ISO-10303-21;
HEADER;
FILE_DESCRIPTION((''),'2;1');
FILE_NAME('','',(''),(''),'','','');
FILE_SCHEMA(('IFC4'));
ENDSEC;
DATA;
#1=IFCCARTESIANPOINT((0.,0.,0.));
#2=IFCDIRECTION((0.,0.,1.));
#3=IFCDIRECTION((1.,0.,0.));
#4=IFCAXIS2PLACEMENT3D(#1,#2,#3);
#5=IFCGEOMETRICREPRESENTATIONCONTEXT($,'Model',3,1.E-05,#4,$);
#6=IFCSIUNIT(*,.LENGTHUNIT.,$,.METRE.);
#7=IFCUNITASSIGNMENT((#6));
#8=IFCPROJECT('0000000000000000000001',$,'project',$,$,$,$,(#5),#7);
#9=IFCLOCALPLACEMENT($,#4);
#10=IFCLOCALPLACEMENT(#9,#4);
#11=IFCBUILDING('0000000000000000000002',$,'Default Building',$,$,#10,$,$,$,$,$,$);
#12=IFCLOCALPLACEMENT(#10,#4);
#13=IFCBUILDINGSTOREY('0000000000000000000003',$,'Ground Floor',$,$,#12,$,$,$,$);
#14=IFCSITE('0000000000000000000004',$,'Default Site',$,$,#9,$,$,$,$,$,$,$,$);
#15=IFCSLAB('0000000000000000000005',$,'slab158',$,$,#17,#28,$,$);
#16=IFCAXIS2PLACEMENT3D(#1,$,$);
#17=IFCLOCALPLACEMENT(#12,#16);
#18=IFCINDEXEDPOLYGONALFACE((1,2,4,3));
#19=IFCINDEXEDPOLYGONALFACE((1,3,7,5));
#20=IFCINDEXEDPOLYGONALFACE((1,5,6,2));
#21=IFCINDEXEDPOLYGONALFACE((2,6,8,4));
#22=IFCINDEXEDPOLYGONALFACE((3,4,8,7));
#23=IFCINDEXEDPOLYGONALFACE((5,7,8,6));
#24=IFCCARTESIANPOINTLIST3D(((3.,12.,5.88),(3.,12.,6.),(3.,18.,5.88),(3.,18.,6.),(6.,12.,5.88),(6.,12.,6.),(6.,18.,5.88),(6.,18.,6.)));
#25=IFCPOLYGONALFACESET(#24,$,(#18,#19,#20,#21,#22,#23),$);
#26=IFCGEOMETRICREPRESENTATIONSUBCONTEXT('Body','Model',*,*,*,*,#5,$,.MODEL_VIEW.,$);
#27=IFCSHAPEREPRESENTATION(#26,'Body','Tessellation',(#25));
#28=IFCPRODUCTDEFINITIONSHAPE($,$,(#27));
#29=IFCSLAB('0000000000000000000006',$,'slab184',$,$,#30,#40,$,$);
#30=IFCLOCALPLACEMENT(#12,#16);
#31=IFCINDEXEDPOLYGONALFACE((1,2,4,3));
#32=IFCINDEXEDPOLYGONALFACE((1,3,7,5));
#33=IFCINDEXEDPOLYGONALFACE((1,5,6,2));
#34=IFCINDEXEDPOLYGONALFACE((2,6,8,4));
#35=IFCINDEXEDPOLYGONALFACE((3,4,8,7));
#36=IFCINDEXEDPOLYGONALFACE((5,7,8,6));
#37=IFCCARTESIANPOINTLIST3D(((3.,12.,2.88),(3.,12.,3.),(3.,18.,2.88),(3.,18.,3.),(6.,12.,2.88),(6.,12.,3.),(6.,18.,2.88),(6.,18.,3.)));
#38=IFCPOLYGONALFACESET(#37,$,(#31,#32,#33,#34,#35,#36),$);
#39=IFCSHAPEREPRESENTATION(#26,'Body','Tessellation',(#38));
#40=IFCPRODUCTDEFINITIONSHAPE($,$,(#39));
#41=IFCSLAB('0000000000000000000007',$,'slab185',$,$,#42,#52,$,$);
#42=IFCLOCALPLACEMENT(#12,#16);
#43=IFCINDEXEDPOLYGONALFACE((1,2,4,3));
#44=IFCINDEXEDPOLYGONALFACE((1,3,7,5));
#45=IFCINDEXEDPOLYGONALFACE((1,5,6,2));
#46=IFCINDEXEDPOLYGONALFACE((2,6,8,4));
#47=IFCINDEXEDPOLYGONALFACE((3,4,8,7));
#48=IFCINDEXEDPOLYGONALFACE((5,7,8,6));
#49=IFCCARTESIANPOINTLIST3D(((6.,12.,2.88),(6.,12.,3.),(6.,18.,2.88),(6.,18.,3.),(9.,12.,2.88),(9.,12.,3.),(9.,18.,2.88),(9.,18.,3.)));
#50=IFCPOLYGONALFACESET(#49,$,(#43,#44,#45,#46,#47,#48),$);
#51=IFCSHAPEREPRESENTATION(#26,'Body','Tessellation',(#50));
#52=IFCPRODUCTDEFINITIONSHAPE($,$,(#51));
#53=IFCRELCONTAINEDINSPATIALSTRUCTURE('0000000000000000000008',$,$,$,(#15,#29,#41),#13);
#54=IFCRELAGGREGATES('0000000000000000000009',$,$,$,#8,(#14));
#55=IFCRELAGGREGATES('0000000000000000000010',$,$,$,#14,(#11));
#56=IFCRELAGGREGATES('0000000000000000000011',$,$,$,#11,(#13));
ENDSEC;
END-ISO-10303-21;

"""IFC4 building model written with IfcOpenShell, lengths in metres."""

from ifc_helpers import new_model, si_unit, frame, origin_with_axes, place, context, subcontext, project, spatial, indexed_curve, outline, extrude, element, save


model = new_model("IFC4")

# Units and contexts
model_context = context("Model", 3, precision=1e-05, world=origin_with_axes())
body_context = subcontext(model_context, "Body", "Model", "MODEL_VIEW")
ifc_project = project(units=[si_unit("LENGTHUNIT", "METRE")], contexts=[model_context])

# Site, building, storey
site_placement = place(None, origin_with_axes())
site = spatial("IfcSite", under=ifc_project, at=site_placement, Name="Default Site")
building_placement = place(site_placement, origin_with_axes())
building = spatial("IfcBuilding", under=site, at=building_placement, Name="Default Building")
storey_placement = place(building_placement, origin_with_axes())
storey = spatial("IfcBuildingStorey", under=building, at=storey_placement, Name="Ground Floor")

# Slabs
for number, where, z_axis, x_axis, name in (
    (1, (3.0, 12.0, 5.88), (0.0, 0.0, 1.0), (1.0, 0.0, 0.0), "slab158"),
    (2, (3.0, 12.0, 2.88), (0.0, 0.0, 1.0), (1.0, 0.0, 0.0), "slab184"),
    (3, (6.0, 12.0, 2.88), (0.0, 0.0, 1.0), (1.0, 0.0, 0.0), "slab185"),
):
    element("IfcSlab", number, at=place(storey_placement, frame(where, z_axis=z_axis, x_axis=x_axis)), inside=storey, Name=name, context=body_context, shape_type="SweptSolid", body=[
        extrude(outline(indexed_curve([(0.0, 0.0), (0.0, 6.0), (3.0, 6.0), (3.0, 0.0), (0.0, 0.0)], self_intersect=False)), origin_with_axes(), (0.0, 0.0, 1.0), 0.12),
    ])

save(model, "model.ifc")
